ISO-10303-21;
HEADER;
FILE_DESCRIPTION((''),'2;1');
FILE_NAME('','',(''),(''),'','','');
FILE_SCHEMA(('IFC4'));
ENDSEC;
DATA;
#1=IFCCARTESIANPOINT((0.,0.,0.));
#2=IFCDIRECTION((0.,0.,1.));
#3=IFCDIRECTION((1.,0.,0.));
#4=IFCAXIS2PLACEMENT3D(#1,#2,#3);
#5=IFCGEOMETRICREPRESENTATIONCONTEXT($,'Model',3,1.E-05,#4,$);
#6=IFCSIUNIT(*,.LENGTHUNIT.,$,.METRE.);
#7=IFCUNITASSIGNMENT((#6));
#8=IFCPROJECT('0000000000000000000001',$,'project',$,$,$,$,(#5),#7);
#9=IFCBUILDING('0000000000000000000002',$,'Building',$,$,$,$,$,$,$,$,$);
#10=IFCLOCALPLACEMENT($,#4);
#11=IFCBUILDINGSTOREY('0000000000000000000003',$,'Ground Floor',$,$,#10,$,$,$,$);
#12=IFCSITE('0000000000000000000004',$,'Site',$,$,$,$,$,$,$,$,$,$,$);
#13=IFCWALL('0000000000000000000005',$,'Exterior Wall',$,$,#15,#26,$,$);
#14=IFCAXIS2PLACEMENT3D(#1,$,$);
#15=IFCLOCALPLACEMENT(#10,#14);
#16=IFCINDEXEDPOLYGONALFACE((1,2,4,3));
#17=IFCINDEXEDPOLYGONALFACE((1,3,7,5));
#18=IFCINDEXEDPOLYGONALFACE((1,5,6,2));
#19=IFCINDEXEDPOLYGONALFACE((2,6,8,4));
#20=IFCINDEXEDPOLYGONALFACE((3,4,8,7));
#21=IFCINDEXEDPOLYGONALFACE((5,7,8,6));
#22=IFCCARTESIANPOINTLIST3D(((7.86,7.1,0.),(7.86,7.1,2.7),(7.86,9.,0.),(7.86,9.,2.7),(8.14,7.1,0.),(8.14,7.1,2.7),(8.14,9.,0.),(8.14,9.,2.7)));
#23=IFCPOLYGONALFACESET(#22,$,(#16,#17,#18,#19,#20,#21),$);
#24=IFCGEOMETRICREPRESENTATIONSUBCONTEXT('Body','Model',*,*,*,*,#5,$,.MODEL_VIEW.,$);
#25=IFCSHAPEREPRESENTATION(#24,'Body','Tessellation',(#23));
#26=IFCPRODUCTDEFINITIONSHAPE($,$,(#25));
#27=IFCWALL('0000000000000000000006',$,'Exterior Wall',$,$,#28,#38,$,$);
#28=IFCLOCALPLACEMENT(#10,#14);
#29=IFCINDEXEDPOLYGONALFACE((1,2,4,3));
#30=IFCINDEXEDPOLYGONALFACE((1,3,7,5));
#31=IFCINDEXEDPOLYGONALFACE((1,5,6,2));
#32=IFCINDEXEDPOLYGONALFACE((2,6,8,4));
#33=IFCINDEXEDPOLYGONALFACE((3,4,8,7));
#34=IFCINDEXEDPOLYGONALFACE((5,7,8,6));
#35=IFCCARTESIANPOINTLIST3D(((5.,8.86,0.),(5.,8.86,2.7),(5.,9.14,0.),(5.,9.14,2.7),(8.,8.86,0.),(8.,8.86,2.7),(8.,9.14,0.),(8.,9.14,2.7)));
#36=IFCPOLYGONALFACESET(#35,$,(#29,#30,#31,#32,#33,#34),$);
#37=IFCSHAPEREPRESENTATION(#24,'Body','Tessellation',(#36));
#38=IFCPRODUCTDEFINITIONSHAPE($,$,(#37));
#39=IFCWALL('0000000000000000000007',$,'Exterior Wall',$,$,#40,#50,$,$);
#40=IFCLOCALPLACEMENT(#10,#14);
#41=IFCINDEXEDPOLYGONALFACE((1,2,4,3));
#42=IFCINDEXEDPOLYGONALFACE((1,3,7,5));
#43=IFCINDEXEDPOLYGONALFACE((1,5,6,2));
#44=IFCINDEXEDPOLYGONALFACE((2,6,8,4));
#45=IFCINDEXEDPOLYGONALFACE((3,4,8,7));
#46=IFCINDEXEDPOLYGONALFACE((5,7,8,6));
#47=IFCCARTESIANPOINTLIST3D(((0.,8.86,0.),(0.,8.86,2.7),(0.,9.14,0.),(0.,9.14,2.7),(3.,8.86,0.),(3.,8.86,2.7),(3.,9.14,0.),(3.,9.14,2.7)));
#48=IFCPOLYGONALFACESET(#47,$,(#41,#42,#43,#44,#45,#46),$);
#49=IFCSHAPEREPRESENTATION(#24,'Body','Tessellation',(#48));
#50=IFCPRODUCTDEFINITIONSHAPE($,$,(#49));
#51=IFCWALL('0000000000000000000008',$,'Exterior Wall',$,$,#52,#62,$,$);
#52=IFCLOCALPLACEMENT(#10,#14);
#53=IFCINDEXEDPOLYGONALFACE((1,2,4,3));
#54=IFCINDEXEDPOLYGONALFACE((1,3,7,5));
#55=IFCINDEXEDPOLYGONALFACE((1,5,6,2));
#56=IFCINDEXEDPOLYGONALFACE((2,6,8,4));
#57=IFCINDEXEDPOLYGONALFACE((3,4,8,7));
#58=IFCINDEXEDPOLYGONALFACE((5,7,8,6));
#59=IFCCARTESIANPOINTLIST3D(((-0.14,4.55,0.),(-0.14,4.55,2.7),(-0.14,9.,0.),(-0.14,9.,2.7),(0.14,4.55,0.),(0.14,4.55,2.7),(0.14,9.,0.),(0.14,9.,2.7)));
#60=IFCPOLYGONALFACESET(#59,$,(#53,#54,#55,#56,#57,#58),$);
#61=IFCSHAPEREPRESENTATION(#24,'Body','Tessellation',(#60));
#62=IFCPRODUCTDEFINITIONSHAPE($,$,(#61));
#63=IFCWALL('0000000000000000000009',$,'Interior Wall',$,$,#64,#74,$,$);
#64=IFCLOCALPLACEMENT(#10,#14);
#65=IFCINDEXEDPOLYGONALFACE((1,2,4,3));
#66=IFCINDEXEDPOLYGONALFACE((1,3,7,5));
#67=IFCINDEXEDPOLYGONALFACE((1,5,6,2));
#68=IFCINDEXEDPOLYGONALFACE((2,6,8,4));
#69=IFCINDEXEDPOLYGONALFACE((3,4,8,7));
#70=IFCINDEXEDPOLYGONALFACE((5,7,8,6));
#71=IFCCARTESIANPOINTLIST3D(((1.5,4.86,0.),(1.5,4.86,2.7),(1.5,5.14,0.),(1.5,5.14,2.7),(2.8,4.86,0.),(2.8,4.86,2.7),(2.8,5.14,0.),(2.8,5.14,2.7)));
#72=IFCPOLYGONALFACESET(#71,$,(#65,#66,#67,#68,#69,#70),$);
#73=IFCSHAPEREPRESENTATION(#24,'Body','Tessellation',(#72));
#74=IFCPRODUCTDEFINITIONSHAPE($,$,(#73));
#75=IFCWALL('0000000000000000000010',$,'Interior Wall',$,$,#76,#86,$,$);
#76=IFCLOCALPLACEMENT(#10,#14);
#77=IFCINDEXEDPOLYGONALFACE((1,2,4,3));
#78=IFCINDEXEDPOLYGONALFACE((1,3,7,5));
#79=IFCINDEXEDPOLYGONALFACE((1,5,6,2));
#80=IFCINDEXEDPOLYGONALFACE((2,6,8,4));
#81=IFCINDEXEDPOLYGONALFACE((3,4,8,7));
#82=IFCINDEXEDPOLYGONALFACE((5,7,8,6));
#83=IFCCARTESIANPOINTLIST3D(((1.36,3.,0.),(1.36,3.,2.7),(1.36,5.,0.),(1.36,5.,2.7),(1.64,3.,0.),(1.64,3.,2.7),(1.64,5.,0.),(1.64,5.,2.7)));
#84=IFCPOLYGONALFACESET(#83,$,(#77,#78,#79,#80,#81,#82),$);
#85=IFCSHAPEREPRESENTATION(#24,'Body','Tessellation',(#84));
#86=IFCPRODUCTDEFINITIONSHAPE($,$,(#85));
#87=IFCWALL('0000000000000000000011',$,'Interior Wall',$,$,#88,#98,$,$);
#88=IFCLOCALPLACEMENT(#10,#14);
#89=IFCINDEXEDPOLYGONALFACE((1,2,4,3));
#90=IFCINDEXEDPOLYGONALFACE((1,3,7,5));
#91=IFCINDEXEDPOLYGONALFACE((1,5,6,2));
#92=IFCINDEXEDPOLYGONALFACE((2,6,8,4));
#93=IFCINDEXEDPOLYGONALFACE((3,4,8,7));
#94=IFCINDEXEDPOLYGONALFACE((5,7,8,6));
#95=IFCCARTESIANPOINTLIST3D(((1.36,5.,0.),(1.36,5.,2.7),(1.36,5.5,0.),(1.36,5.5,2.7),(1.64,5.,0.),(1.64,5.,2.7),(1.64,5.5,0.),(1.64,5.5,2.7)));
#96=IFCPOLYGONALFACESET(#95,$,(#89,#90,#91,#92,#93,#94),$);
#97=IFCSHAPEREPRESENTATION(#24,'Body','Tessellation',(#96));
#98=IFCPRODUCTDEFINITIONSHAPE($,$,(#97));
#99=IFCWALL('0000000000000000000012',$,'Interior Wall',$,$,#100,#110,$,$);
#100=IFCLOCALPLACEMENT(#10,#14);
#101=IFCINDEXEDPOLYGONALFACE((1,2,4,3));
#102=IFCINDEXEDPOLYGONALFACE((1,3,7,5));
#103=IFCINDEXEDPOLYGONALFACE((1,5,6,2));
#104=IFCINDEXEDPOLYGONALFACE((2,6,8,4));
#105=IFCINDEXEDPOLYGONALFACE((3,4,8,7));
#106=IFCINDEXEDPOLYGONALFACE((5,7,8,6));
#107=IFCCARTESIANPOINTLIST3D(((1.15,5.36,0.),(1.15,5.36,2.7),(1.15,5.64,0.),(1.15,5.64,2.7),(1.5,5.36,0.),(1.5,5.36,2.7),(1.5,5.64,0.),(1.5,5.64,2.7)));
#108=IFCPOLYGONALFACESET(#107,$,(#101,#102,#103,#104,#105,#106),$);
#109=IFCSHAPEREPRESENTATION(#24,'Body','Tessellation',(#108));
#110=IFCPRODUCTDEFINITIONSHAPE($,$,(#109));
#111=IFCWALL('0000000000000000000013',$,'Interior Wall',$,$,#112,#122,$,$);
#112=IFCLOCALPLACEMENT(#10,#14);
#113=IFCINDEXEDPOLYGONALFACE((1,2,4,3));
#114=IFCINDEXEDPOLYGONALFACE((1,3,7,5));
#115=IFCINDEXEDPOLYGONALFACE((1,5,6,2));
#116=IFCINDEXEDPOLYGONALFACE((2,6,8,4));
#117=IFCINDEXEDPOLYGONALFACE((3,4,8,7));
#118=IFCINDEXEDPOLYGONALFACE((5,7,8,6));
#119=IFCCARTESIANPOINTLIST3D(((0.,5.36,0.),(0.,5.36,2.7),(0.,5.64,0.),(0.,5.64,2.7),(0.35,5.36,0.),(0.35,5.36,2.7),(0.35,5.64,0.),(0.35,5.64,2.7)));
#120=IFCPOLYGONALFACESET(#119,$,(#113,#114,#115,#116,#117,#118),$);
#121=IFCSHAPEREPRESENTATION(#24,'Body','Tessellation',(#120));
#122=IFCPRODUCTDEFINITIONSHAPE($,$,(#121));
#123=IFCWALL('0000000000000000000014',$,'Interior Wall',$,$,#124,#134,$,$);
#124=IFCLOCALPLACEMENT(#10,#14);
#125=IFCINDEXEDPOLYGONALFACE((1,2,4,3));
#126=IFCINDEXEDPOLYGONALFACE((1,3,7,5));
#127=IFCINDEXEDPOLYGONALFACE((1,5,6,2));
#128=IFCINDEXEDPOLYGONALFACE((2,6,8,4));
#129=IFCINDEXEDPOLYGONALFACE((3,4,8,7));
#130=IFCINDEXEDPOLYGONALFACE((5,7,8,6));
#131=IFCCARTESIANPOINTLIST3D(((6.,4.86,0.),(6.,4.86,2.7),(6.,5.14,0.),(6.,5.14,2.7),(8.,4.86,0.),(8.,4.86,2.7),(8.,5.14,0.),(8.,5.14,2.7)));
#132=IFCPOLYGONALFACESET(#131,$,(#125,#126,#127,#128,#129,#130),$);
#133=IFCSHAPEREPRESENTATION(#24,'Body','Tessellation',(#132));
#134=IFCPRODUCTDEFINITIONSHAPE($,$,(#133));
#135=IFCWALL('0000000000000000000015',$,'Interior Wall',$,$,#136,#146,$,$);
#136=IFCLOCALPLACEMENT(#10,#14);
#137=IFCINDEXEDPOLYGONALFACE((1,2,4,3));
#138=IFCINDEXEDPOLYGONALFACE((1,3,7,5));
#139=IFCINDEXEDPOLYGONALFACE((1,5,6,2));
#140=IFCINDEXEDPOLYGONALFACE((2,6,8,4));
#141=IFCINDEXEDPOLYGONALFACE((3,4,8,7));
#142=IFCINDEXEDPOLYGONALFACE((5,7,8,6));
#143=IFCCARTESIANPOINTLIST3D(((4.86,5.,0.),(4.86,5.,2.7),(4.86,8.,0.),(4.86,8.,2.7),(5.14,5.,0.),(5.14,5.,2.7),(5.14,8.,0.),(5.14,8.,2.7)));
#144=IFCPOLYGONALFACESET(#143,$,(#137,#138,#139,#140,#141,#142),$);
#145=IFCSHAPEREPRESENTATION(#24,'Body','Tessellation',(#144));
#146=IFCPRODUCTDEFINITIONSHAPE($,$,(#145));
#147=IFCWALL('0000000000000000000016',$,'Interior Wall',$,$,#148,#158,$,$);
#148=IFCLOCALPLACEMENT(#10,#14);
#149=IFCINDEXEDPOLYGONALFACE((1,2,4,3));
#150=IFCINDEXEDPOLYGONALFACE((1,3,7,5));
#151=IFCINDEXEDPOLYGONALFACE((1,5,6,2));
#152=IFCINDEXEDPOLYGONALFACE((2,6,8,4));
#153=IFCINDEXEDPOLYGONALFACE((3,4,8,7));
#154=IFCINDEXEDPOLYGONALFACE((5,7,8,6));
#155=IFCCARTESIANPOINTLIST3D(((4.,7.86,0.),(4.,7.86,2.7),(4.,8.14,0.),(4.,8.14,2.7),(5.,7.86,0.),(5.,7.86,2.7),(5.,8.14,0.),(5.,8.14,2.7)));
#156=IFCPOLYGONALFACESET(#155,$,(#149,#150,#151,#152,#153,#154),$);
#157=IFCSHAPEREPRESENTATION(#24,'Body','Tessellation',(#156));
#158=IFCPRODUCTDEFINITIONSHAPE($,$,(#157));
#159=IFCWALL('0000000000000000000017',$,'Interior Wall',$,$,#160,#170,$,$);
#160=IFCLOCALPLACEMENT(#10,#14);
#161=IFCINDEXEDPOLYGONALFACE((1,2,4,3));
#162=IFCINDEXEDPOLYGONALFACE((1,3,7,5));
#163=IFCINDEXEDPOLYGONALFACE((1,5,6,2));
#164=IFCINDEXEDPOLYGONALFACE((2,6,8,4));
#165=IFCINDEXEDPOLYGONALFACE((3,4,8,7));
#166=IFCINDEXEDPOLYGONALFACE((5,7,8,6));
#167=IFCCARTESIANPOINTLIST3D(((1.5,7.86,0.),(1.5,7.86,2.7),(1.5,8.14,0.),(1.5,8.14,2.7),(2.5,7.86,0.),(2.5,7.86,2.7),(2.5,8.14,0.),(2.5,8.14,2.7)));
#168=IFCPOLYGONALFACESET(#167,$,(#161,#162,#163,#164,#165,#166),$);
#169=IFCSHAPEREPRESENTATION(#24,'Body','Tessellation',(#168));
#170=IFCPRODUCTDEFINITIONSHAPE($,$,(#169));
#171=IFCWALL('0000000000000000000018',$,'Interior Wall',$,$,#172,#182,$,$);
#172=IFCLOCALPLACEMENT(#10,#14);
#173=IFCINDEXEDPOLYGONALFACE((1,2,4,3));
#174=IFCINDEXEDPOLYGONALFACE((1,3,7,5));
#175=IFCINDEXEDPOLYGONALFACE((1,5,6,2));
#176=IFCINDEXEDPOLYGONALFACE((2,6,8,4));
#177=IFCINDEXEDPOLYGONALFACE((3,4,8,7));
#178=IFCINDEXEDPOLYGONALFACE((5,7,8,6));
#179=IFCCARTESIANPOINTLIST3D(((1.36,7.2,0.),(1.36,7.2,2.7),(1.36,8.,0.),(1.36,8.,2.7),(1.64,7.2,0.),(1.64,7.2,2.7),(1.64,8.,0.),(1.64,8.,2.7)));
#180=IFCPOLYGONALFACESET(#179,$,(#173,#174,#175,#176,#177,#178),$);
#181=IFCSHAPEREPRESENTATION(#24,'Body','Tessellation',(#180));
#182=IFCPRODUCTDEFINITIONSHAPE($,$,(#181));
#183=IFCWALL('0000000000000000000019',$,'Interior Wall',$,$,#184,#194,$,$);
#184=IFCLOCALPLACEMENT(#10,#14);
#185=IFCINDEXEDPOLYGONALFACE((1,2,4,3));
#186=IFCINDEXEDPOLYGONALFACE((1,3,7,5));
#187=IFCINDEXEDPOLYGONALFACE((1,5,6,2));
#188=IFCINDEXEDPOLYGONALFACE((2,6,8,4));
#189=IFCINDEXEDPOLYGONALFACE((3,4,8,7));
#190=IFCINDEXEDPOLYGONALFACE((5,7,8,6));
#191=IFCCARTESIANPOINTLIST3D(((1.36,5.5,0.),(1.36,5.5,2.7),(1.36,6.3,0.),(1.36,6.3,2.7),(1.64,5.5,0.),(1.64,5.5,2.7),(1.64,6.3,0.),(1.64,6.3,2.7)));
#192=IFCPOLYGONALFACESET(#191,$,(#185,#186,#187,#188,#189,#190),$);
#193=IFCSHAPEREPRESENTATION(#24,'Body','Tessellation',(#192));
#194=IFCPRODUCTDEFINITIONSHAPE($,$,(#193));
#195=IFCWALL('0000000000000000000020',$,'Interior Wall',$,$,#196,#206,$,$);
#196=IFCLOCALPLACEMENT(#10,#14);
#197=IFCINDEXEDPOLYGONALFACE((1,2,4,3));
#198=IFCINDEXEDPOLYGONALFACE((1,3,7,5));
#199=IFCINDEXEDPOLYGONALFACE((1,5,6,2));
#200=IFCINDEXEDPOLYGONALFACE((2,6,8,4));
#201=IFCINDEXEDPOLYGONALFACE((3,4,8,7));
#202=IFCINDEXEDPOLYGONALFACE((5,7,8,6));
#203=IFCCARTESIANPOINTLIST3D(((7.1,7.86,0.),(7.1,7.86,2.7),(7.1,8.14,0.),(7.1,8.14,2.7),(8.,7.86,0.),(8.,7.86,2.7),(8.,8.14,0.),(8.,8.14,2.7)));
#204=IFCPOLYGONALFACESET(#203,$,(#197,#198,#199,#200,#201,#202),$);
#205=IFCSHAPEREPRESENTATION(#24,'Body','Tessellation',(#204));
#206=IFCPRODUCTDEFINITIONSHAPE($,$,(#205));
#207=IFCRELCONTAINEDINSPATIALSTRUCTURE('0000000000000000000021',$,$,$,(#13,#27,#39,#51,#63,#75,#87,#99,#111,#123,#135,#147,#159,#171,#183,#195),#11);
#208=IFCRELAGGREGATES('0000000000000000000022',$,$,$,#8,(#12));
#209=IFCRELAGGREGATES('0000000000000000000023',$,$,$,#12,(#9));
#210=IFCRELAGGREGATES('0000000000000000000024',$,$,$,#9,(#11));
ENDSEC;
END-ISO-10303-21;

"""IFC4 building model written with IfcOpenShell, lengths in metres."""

from ifc_helpers import new_model, si_unit, frame, origin_with_axes, place, context, subcontext, project, spatial, indexed_curve, outline, extrude, element, save


model = new_model("IFC4")

# Units and contexts
model_context = context("Model", 3, precision=1e-05, world=origin_with_axes())
body_context = subcontext(model_context, "Body", "Model", "MODEL_VIEW")
ifc_project = project(units=[si_unit("LENGTHUNIT", "METRE")], contexts=[model_context])

# Site, building, storey
site = spatial("IfcSite", under=ifc_project, Name="Site")
building = spatial("IfcBuilding", under=site, Name="Building")
storey_placement = place(None, origin_with_axes())
storey = spatial("IfcBuildingStorey", under=building, at=storey_placement, Name="Ground Floor")

# Walls
wall_1_placement = place(storey_placement, frame((8.0, 7.1, 0.0), z_axis=(0.0, 0.0, 1.0), x_axis=(0.0, 1.0, 0.0)))
element("IfcWall", 1, at=wall_1_placement, inside=storey, Name="Exterior Wall", context=body_context, shape_type="SweptSolid", body=[
    extrude(outline(indexed_curve([(0.0, 0.0), (0.0, 0.28), (1.9, 0.28), (1.9, 0.0), (0.0, 0.0)], self_intersect=False)), frame((0.0, -0.14, 0.0), z_axis=(0.0, 0.0, 1.0), x_axis=(1.0, 0.0, 0.0)), (0.0, 0.0, 1.0), 2.7),
])
for number, where, z_axis, x_axis, name in (
    (2, (8.0, 9.0, 0.0), (0.0, 0.0, 1.0), (-1.0, 0.0, 0.0), "Exterior Wall"),
    (3, (3.0, 9.0, 0.0), (0.0, 0.0, 1.0), (-1.0, 0.0, 0.0), "Exterior Wall"),
):
    element("IfcWall", number, at=place(storey_placement, frame(where, z_axis=z_axis, x_axis=x_axis)), inside=storey, Name=name, context=body_context, shape_type="SweptSolid", body=[
        extrude(outline(indexed_curve([(0.0, 0.0), (0.0, 0.28), (3.0, 0.28), (3.0, 0.0), (0.0, 0.0)], self_intersect=False)), frame((0.0, -0.14, 0.0), z_axis=(0.0, 0.0, 1.0), x_axis=(1.0, 0.0, 0.0)), (0.0, 0.0, 1.0), 2.7),
    ])
wall_2_placement = place(storey_placement, frame((0.0, 9.0, 0.0), z_axis=(0.0, 0.0, 1.0), x_axis=(0.0, -1.0, 0.0)))
element("IfcWall", 4, at=wall_2_placement, inside=storey, Name="Exterior Wall", context=body_context, shape_type="SweptSolid", body=[
    extrude(outline(indexed_curve([(0.0, 0.0), (0.0, 0.28), (4.45, 0.28), (4.45, 0.0), (0.0, 0.0)], self_intersect=False)), frame((0.0, -0.14, 0.0), z_axis=(0.0, 0.0, 1.0), x_axis=(1.0, 0.0, 0.0)), (0.0, 0.0, 1.0), 2.7),
])
wall_3_placement = place(storey_placement, frame((2.8, 5.0, 0.0), z_axis=(0.0, 0.0, 1.0), x_axis=(-1.0, 0.0, 0.0)))
element("IfcWall", 5, at=wall_3_placement, inside=storey, Name="Interior Wall", context=body_context, shape_type="SweptSolid", body=[
    extrude(outline(indexed_curve([(0.0, 0.0), (0.0, 0.28), (1.3, 0.28), (1.3, 0.0), (0.0, 0.0)], self_intersect=False)), frame((0.0, -0.14, 0.0), z_axis=(0.0, 0.0, 1.0), x_axis=(1.0, 0.0, 0.0)), (0.0, 0.0, 1.0), 2.7),
])
wall_4_placement = place(storey_placement, frame((1.5, 5.0, 0.0), z_axis=(0.0, 0.0, 1.0), x_axis=(0.0, -1.0, 0.0)))
element("IfcWall", 6, at=wall_4_placement, inside=storey, Name="Interior Wall", context=body_context, shape_type="SweptSolid", body=[
    extrude(outline(indexed_curve([(0.0, 0.0), (0.0, 0.28), (2.0, 0.28), (2.0, 0.0), (0.0, 0.0)], self_intersect=False)), frame((0.0, -0.14, 0.0), z_axis=(0.0, 0.0, 1.0), x_axis=(1.0, 0.0, 0.0)), (0.0, 0.0, 1.0), 2.7),
])
wall_5_placement = place(storey_placement, frame((1.5, 5.0, 0.0), z_axis=(0.0, 0.0, 1.0), x_axis=(0.0, 1.0, 0.0)))
element("IfcWall", 7, at=wall_5_placement, inside=storey, Name="Interior Wall", context=body_context, shape_type="SweptSolid", body=[
    extrude(outline(indexed_curve([(0.0, 0.0), (0.0, 0.28), (0.5, 0.28), (0.5, 0.0), (0.0, 0.0)], self_intersect=False)), frame((0.0, -0.14, 0.0), z_axis=(0.0, 0.0, 1.0), x_axis=(1.0, 0.0, 0.0)), (0.0, 0.0, 1.0), 2.7),
])
for number, where, z_axis, x_axis, name in (
    (8, (1.5, 5.5, 0.0), (0.0, 0.0, 1.0), (-1.0, 0.0, 0.0), "Interior Wall"),
    (9, (0.35, 5.5, 0.0), (0.0, 0.0, 1.0), (-1.0, 0.0, 0.0), "Interior Wall"),
):
    element("IfcWall", number, at=place(storey_placement, frame(where, z_axis=z_axis, x_axis=x_axis)), inside=storey, Name=name, context=body_context, shape_type="SweptSolid", body=[
        extrude(outline(indexed_curve([(0.0, 0.0), (0.0, 0.28), (0.35, 0.28), (0.35, 0.0), (0.0, 0.0)], self_intersect=False)), frame((0.0, -0.14, 0.0), z_axis=(0.0, 0.0, 1.0), x_axis=(1.0, 0.0, 0.0)), (0.0, 0.0, 1.0), 2.7),
    ])
wall_6_placement = place(storey_placement, frame((8.0, 5.0, 0.0), z_axis=(0.0, 0.0, 1.0), x_axis=(-1.0, 0.0, 0.0)))
element("IfcWall", 10, at=wall_6_placement, inside=storey, Name="Interior Wall", context=body_context, shape_type="SweptSolid", body=[
    extrude(outline(indexed_curve([(0.0, 0.0), (0.0, 0.28), (2.0, 0.28), (2.0, 0.0), (0.0, 0.0)], self_intersect=False)), frame((0.0, -0.14, 0.0), z_axis=(0.0, 0.0, 1.0), x_axis=(1.0, 0.0, 0.0)), (0.0, 0.0, 1.0), 2.7),
])
wall_7_placement = place(storey_placement, frame((5.0, 5.0, 0.0), z_axis=(0.0, 0.0, 1.0), x_axis=(0.0, 1.0, 0.0)))
element("IfcWall", 11, at=wall_7_placement, inside=storey, Name="Interior Wall", context=body_context, shape_type="SweptSolid", body=[
    extrude(outline(indexed_curve([(0.0, 0.0), (0.0, 0.28), (3.0, 0.28), (3.0, 0.0), (0.0, 0.0)], self_intersect=False)), frame((0.0, -0.14, 0.0), z_axis=(0.0, 0.0, 1.0), x_axis=(1.0, 0.0, 0.0)), (0.0, 0.0, 1.0), 2.7),
])
for number, where, z_axis, x_axis, name in (
    (12, (5.0, 8.0, 0.0), (0.0, 0.0, 1.0), (-1.0, 0.0, 0.0), "Interior Wall"),
    (13, (2.5, 8.0, 0.0), (0.0, 0.0, 1.0), (-1.0, 0.0, 0.0), "Interior Wall"),
):
    element("IfcWall", number, at=place(storey_placement, frame(where, z_axis=z_axis, x_axis=x_axis)), inside=storey, Name=name, context=body_context, shape_type="SweptSolid", body=[
        extrude(outline(indexed_curve([(0.0, 0.0), (0.0, 0.28), (1.0, 0.28), (1.0, 0.0), (0.0, 0.0)], self_intersect=False)), frame((0.0, -0.14, 0.0), z_axis=(0.0, 0.0, 1.0), x_axis=(1.0, 0.0, 0.0)), (0.0, 0.0, 1.0), 2.7),
    ])
for number, where, z_axis, x_axis, name in (
    (14, (1.5, 8.0, 0.0), (0.0, 0.0, 1.0), (0.0, -1.0, 0.0), "Interior Wall"),
    (15, (1.5, 6.3, 0.0), (0.0, 0.0, 1.0), (0.0, -1.0, 0.0), "Interior Wall"),
):
    element("IfcWall", number, at=place(storey_placement, frame(where, z_axis=z_axis, x_axis=x_axis)), inside=storey, Name=name, context=body_context, shape_type="SweptSolid", body=[
        extrude(outline(indexed_curve([(0.0, 0.0), (0.0, 0.28), (0.8, 0.28), (0.8, 0.0), (0.0, 0.0)], self_intersect=False)), frame((0.0, -0.14, 0.0), z_axis=(0.0, 0.0, 1.0), x_axis=(1.0, 0.0, 0.0)), (0.0, 0.0, 1.0), 2.7),
    ])
for number, where, z_axis, x_axis, name in (
    (16, (8.0, 8.0, 0.0), (0.0, 0.0, 1.0), (-1.0, 0.0, 0.0), "Interior Wall"),
):
    element("IfcWall", number, at=place(storey_placement, frame(where, z_axis=z_axis, x_axis=x_axis)), inside=storey, Name=name, context=body_context, shape_type="SweptSolid", body=[
        extrude(outline(indexed_curve([(0.0, 0.0), (0.0, 0.28), (0.9, 0.28), (0.9, 0.0), (0.0, 0.0)], self_intersect=False)), frame((0.0, -0.14, 0.0), z_axis=(0.0, 0.0, 1.0), x_axis=(1.0, 0.0, 0.0)), (0.0, 0.0, 1.0), 2.7),
    ])

save(model, "model.ifc")
